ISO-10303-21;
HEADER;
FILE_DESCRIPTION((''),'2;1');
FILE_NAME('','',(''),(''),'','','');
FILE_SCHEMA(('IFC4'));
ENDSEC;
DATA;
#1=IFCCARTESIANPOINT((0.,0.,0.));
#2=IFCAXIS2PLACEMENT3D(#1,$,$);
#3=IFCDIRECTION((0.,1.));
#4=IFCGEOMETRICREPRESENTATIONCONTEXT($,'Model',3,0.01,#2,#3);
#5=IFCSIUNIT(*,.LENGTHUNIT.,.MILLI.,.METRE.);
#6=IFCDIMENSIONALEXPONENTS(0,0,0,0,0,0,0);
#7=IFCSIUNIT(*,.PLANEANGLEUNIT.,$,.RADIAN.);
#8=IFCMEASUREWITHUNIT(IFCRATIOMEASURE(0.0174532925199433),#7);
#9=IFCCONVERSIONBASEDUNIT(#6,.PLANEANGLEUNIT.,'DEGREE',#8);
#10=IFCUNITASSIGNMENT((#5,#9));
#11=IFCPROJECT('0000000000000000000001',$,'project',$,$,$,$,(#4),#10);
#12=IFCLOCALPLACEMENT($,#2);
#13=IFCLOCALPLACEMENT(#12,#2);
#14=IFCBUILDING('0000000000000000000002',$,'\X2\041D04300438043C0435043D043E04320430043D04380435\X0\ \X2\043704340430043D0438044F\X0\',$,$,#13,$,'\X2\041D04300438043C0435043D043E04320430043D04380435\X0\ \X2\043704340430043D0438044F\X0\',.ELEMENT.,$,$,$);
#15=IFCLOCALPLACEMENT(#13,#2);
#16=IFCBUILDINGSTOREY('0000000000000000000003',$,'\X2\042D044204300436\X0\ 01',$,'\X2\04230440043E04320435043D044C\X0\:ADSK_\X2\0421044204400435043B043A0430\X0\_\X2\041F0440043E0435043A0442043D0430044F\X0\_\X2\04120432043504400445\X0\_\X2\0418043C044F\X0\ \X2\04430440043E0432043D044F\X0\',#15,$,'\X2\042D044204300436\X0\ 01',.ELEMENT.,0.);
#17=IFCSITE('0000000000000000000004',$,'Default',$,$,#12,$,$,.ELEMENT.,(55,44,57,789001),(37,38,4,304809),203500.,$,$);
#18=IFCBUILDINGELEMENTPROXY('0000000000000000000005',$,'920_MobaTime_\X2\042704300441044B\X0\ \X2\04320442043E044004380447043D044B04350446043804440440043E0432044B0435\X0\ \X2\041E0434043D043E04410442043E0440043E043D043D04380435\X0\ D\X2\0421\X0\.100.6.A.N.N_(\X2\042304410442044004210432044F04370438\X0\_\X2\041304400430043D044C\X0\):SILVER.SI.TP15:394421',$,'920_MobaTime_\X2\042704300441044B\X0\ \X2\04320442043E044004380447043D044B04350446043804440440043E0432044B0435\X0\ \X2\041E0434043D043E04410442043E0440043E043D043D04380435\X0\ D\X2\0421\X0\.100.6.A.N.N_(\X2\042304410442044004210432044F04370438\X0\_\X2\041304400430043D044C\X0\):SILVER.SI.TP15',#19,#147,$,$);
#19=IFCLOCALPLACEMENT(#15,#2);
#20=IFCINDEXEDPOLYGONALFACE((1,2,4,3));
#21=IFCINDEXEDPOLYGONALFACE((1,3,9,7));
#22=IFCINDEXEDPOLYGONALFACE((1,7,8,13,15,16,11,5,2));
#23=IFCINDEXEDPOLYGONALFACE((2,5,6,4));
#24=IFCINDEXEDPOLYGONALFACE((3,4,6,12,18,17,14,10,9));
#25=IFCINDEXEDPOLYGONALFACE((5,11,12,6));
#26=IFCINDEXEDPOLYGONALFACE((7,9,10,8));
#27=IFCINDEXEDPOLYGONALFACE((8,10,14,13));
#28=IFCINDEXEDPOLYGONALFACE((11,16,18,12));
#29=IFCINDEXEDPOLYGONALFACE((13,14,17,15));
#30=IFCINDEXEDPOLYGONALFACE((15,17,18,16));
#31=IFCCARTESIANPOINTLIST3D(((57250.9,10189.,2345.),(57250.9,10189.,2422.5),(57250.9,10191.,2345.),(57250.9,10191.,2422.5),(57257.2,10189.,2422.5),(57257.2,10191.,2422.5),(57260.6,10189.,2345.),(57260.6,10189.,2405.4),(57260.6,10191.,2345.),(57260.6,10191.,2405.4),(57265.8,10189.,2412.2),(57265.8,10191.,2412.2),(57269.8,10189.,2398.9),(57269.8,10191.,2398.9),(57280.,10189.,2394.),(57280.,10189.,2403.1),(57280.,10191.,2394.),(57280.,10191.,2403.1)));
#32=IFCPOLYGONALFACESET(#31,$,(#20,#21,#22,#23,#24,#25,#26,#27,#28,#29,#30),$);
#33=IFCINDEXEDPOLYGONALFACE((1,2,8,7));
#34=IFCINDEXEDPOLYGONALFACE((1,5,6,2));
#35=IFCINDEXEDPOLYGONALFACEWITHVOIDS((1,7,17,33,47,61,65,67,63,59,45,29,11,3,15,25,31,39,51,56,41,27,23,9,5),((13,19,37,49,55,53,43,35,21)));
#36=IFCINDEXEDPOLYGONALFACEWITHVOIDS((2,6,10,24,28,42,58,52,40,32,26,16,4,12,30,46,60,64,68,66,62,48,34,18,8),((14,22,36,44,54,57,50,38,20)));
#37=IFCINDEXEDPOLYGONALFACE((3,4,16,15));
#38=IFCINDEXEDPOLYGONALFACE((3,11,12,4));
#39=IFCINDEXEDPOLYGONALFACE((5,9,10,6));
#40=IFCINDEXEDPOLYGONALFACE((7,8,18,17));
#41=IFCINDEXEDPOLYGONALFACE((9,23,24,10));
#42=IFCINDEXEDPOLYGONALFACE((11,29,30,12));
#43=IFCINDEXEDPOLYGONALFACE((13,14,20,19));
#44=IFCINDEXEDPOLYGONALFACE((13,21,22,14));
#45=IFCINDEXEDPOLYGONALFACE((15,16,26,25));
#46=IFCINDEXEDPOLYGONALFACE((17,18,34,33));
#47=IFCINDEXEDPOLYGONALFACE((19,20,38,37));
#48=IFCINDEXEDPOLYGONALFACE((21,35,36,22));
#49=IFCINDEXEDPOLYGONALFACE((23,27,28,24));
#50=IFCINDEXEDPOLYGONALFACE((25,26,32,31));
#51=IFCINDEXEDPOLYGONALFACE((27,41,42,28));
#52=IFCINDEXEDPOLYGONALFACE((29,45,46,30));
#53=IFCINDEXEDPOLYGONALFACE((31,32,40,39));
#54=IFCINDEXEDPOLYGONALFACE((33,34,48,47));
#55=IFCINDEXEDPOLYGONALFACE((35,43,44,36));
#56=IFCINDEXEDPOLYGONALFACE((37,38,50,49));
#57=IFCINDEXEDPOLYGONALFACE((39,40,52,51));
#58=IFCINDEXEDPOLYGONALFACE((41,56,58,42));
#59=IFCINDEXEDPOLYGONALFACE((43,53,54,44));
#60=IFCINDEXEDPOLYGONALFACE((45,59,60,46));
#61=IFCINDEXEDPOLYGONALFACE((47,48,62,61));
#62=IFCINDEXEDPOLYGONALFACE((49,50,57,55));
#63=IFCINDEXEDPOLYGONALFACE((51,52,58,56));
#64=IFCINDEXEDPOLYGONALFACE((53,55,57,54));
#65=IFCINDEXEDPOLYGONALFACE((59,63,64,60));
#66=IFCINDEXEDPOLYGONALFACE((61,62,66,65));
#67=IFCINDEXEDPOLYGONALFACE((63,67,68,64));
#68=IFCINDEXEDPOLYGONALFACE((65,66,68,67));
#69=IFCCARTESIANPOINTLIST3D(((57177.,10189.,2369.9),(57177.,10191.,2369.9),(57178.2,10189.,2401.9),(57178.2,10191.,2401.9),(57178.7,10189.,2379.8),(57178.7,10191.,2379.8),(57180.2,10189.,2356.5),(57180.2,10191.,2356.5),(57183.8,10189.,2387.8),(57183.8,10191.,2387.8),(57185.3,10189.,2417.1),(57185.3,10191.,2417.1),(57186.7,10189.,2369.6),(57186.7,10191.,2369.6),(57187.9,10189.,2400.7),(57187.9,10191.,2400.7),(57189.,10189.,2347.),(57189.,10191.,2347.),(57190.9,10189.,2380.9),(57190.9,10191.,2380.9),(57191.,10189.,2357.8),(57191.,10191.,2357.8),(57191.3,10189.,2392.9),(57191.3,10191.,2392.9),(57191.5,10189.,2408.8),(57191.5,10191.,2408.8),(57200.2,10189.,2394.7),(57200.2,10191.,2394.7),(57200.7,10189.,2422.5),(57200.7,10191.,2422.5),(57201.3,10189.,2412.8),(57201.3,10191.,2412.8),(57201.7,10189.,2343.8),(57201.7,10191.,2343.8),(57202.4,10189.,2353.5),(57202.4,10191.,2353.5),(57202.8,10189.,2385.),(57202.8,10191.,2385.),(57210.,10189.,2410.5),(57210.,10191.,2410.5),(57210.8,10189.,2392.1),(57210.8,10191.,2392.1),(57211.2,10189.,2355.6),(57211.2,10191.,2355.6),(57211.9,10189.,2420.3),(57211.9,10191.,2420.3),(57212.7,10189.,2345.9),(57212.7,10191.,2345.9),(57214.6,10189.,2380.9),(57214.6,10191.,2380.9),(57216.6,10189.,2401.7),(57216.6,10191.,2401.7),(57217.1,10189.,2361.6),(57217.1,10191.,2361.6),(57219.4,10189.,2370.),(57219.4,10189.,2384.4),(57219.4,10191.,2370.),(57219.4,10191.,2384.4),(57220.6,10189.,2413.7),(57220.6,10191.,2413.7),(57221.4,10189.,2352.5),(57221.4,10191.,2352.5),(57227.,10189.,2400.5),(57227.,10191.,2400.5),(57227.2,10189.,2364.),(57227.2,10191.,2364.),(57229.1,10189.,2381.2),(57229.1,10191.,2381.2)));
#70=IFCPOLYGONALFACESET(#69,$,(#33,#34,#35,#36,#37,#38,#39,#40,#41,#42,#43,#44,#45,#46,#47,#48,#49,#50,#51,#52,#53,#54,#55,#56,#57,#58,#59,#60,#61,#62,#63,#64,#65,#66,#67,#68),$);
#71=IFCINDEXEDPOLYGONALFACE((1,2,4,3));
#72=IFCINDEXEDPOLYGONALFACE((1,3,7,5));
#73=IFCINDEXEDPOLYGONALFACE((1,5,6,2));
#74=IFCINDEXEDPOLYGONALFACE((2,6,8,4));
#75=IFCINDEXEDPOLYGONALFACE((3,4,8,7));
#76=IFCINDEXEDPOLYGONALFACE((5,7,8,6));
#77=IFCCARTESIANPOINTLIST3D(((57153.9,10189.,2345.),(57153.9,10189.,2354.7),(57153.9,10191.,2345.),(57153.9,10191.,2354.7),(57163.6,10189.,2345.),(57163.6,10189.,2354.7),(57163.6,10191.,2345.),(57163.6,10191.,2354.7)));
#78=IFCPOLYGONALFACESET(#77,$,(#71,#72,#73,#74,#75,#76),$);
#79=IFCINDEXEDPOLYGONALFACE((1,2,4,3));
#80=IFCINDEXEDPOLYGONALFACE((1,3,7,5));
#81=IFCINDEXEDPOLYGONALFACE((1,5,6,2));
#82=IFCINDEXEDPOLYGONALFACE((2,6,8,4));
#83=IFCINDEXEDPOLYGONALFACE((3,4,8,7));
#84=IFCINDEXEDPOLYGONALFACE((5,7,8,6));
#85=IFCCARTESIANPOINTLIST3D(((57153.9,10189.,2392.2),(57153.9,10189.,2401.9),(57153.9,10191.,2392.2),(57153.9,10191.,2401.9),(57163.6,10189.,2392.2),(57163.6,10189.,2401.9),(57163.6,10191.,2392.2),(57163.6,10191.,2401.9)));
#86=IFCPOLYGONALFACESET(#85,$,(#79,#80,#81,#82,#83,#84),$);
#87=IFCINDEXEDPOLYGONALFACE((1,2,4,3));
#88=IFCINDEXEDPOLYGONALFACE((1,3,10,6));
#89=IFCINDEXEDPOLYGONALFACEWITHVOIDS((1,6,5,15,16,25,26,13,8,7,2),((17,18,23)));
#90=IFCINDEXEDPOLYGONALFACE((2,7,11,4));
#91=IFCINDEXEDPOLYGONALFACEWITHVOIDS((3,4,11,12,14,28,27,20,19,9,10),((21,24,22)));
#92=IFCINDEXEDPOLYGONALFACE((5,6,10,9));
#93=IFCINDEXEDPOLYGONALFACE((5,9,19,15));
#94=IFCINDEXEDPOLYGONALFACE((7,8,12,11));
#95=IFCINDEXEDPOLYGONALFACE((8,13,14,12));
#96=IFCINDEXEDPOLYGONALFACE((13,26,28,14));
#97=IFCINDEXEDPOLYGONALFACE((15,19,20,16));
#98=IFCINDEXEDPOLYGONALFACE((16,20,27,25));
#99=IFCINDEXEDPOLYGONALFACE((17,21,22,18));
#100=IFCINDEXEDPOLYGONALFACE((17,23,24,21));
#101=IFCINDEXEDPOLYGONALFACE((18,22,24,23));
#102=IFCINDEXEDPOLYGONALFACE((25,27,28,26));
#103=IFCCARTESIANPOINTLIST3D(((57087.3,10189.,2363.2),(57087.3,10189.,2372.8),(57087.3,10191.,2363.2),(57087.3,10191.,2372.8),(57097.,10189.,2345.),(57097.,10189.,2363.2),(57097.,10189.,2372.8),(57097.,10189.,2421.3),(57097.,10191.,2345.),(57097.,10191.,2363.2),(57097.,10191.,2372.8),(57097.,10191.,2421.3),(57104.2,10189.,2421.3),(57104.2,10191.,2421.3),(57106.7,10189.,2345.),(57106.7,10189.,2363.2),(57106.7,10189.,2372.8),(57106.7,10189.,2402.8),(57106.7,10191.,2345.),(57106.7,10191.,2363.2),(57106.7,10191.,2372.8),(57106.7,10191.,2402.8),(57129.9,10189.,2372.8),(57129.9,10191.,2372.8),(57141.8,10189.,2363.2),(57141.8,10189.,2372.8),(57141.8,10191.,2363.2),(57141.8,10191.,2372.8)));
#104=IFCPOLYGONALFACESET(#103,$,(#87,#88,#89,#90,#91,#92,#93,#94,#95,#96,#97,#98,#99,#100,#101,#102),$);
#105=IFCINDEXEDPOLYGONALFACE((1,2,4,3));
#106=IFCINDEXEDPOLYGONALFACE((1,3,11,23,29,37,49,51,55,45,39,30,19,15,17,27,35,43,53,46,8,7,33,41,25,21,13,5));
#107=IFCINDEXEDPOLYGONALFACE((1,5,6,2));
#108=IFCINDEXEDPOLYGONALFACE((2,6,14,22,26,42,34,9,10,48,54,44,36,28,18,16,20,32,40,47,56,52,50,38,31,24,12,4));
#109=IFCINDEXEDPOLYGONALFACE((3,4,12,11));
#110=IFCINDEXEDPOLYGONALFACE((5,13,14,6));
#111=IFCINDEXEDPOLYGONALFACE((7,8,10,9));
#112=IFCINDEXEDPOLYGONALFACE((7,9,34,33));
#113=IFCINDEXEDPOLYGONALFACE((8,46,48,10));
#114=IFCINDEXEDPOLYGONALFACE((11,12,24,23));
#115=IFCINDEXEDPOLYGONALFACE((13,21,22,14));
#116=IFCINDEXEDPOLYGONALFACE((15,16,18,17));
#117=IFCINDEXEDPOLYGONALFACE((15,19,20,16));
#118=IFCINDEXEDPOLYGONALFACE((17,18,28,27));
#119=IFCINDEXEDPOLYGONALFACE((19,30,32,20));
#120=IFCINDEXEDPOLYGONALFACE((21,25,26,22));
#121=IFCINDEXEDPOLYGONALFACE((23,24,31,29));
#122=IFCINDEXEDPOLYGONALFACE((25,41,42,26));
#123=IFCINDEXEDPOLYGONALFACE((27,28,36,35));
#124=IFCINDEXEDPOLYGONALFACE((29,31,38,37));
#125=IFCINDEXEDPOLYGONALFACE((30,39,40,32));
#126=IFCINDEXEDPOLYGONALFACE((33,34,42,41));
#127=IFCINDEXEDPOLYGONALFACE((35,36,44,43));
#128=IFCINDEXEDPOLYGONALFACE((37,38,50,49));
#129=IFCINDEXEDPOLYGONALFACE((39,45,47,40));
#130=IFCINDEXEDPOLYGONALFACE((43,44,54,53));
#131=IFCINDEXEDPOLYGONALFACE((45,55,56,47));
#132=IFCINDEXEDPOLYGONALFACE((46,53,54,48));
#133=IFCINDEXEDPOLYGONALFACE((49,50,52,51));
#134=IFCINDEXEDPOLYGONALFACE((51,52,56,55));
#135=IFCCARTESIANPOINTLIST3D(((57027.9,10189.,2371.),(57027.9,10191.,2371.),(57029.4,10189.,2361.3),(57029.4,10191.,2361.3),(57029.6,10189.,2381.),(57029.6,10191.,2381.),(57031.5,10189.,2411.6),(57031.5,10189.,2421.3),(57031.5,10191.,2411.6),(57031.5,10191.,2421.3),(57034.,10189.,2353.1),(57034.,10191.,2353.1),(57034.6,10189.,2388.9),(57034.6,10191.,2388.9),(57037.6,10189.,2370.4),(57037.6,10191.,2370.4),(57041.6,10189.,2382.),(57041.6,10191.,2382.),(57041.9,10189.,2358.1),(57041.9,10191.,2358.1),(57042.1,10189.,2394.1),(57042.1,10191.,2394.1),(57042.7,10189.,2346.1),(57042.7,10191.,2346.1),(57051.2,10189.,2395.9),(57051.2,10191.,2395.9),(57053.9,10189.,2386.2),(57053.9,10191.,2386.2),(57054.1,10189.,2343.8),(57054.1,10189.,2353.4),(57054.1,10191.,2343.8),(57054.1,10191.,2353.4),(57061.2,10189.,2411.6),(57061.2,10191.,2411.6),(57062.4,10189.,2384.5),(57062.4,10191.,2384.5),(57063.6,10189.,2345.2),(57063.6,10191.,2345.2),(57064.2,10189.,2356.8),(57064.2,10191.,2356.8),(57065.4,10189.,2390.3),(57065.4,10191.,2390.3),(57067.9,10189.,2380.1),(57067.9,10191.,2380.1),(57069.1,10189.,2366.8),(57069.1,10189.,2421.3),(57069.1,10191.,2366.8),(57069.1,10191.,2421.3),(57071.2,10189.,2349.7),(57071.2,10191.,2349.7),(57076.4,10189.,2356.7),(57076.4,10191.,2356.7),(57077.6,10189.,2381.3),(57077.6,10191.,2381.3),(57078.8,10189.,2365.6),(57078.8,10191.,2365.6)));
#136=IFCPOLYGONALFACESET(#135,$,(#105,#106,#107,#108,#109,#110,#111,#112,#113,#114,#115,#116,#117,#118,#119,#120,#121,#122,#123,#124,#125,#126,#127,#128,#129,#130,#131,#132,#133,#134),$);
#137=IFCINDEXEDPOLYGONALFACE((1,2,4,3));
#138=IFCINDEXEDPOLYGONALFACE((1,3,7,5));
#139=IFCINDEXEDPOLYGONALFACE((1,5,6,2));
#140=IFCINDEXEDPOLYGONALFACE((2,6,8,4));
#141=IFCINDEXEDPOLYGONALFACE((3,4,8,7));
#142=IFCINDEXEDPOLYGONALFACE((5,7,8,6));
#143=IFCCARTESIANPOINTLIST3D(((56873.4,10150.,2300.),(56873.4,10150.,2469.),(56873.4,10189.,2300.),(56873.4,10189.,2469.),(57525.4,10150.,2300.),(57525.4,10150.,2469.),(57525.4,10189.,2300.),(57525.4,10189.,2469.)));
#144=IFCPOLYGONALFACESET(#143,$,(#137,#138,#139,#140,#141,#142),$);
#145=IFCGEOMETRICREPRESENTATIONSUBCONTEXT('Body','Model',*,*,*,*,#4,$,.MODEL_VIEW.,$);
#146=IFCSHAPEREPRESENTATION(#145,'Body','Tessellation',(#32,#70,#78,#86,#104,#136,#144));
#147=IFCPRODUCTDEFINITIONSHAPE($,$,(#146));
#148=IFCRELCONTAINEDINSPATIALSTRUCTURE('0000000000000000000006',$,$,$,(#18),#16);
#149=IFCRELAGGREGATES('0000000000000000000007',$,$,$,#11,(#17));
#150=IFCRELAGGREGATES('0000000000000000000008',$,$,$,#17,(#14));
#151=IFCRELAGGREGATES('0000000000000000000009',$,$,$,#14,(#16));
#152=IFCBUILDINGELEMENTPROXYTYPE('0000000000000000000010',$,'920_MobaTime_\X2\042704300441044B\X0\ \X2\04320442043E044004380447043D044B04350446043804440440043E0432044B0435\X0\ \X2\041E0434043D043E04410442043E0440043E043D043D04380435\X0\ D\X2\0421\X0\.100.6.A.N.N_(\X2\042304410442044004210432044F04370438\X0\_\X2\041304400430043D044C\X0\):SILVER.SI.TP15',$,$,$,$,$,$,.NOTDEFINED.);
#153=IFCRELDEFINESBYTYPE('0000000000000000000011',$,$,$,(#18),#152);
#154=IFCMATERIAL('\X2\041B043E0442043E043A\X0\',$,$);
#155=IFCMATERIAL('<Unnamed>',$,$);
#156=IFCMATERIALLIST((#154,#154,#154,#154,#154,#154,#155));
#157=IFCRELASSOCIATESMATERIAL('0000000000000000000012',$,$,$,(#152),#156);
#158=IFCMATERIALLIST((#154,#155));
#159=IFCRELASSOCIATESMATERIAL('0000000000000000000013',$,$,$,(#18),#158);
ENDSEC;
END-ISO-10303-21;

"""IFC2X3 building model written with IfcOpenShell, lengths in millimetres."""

from ifc_helpers import new_model, entity, si_unit, converted_unit, direction, frame, origin, origin_2d_with_axis, place, context, subcontext, project, spatial, polyline, rectangle, outline, extrude, source, transform, mapped, material, material_list, type_object, type_shapes, element, save


model = new_model("IFC2X3")

# Units and contexts
model_context = context("Model", 3, precision=0.01, world=origin(), true_north=direction((0.0, 1.0)))
body_context = subcontext(model_context, "Body", "Model", "MODEL_VIEW")
ifc_project = project(units=[si_unit("LENGTHUNIT", "METRE", prefix="MILLI"), converted_unit("PLANEANGLEUNIT", "DEGREE", entity("IfcRatioMeasure", 0.0174532925199433), si_unit("PLANEANGLEUNIT", "RADIAN"), dimensions=[0, 0, 0, 0, 0, 0, 0])], contexts=[model_context])

# Site, building, storey
site_placement = place(None, origin())
site = spatial("IfcSite", under=ifc_project, at=site_placement, Name="Default", CompositionType="ELEMENT", RefLatitude=(55, 44, 57, 789001), RefLongitude=(37, 38, 4, 304809), RefElevation=203500.0)
building_placement = place(site_placement, origin())
building = spatial("IfcBuilding", under=site, at=building_placement, Name="Наименование здания", LongName="Наименование здания", CompositionType="ELEMENT")
storey_placement = place(building_placement, origin())
storey = spatial("IfcBuildingStorey", under=building, at=storey_placement, Name="Этаж 01", ObjectType="Уровень:ADSK_Стрелка_Проектная_Вверх_Имя уровня", LongName="Этаж 01", CompositionType="ELEMENT", Elevation=0.0)

# Building element proxy
ifc_material_1 = material(Name="Лоток")
ifc_material_2 = material(Name="<Unnamed>")
ifc_material_list_1 = material_list([ifc_material_1, ifc_material_1, ifc_material_1, ifc_material_1, ifc_material_1, ifc_material_1, ifc_material_2])
building_element_proxy_type = type_object("IfcBuildingElementProxyType", Name="920_MobaTime_Часы вторичныецифровые Односторонние DС.100.6.A.N.N_(УстрСвязи_Грань):SILVER.SI.TP15", PredefinedType="NOTDEFINED", material=ifc_material_list_1)
shared_shape = source(origin(), body_context, "Body", "SweptSolid", [
    extrude(outline(polyline([(-49.3, -13.1), (28.2, -13.1), (28.2, -6.8), (17.9, 1.8), (8.8, 16.0), (-0.3, 16.0), (4.6, 5.8), (11.1, -3.4), (-49.3, -3.4), (-49.3, -13.1)])), frame((-64.6, 9.8, 39.0), z_axis=(0.0, 0.0, 1.0), x_axis=(0.0, 1.0, 0.0)), (0.0, 0.0, 1.0), 2.0),
    extrude(outline(polyline([(2.2, -27.6), (19.0, -27.6), (30.5, -16.1), (33.3, -4.9), (31.0, 5.8), (21.8, 17.2), (5.2, 27.3), (-11.1, 33.0), (-24.0, 32.7), (-33.6, 27.6), (-40.3, 18.6), (-42.8, 5.7), (-38.0, -6.3), (-27.2, -14.9), (-17.5, -17.7), (-8.2, -16.4), (-0.3, -11.9), (5.1, -4.5), (7.3, 6.2), (4.0, 17.2), (18.4, 7.3), (23.6, -2.4), (22.0, -11.4), (14.2, -18.4), (5.3, -18.3), (2.2, -27.6)]), holes=[polyline([(-9.0, 23.3), (-1.3, 14.3), (-2.5, 2.0), (-11.4, -7.0), (-23.4, -6.0), (-32.2, 2.9), (-31.2, 15.1), (-25.6, 22.1), (-17.5, 24.9), (-9.0, 23.3)])]), frame((-2.7, 3.6, 39.0), z_axis=(0.0, 0.0, 1.0), x_axis=(-0.427649, 0.903945, 0.0)), (0.0, 0.0, 1.0), 2.0),
    extrude(rectangle(XDim=9.7, YDim=9.7, at=origin_2d_with_axis()), frame((40.6, -34.7, 39.0)), (0.0, 0.0, 1.0), 2.0),
    extrude(rectangle(XDim=9.7, YDim=9.7, at=origin_2d_with_axis()), frame((40.6, 12.6, 39.0)), (0.0, 0.0, 1.0), 2.0),
    extrude(outline(polyline([(-0.9, -28.1), (8.8, -28.1), (8.8, -9.9), (18.5, -9.9), (18.5, -0.2), (8.8, -0.2), (8.8, 48.3), (1.5, 48.3), (-36.0, -0.2), (-36.0, -9.9), (-0.9, -9.9), (-0.9, -28.1)]), holes=[polyline([(-0.9, -0.2), (-24.1, -0.2), (-0.9, 29.7), (-0.9, -0.2)])]), frame((93.6, -11.4, 39.0)), (0.0, 0.0, 1.0), 2.0),
    extrude(outline(polyline([(3.3, -28.3), (12.5, -28.3), (20.5, -25.0), (26.8, -18.9), (30.7, -10.0), (31.4, 1.6), (26.9, 11.8), (20.1, 18.4), (11.1, 22.3), (1.0, 23.3), (-7.9, 20.4), (-14.9, 14.5), (-18.9, 6.2), (-17.1, -9.0), (-36.7, 0.5), (-29.1, 29.2), (-38.5, 31.7), (-48.1, -4.6), (-11.6, -23.1), (-8.0, -14.0), (-10.8, -7.6), (-10.2, 1.1), (-3.0, 11.8), (9.2, 12.8), (20.0, 5.5), (21.4, -7.5), (15.5, -16.4), (4.6, -18.6), (3.3, -28.3)])), frame((147.1, -8.5, 39.0), z_axis=(0.0, 0.0, 1.0), x_axis=(0.256974, -0.966418, 0.0)), (0.0, 0.0, 1.0), 2.0),
    extrude(rectangle(XDim=652.0, YDim=169.0, at=origin_2d_with_axis()), frame((0.0, 0.0, 0.0), z_axis=(0.0, 0.0, 1.0), x_axis=(-1.0, 0.0, 0.0)), (0.0, 0.0, 1.0), 39.0),
])
type_shapes(building_element_proxy_type, [shared_shape])
ifc_material_list_2 = material_list([ifc_material_1, ifc_material_2])
for number, where, z_axis, x_axis, name in (
    (1, (57199.4, 10150.0, 2384.5), (0.0, 1.0, 0.0), (-1.0, 0.0, 0.0), "920_MobaTime_Часы вторичныецифровые Односторонние DС.100.6.A.N.N_(УстрСвязи_Грань):SILVER.SI.TP15:394421"),
):
    element("IfcBuildingElementProxy", number, at=place(storey_placement, frame(where, z_axis=z_axis, x_axis=x_axis)), inside=storey, type_object=building_element_proxy_type, material=ifc_material_list_2, Name=name, ObjectType="920_MobaTime_Часы вторичныецифровые Односторонние DС.100.6.A.N.N_(УстрСвязи_Грань):SILVER.SI.TP15", context=body_context, shape_type="MappedRepresentation", body=[
        mapped(shared_shape, transform((0.0, 0.0, 0.0), scale=1.0)),
    ])

save(model, "model.ifc")
